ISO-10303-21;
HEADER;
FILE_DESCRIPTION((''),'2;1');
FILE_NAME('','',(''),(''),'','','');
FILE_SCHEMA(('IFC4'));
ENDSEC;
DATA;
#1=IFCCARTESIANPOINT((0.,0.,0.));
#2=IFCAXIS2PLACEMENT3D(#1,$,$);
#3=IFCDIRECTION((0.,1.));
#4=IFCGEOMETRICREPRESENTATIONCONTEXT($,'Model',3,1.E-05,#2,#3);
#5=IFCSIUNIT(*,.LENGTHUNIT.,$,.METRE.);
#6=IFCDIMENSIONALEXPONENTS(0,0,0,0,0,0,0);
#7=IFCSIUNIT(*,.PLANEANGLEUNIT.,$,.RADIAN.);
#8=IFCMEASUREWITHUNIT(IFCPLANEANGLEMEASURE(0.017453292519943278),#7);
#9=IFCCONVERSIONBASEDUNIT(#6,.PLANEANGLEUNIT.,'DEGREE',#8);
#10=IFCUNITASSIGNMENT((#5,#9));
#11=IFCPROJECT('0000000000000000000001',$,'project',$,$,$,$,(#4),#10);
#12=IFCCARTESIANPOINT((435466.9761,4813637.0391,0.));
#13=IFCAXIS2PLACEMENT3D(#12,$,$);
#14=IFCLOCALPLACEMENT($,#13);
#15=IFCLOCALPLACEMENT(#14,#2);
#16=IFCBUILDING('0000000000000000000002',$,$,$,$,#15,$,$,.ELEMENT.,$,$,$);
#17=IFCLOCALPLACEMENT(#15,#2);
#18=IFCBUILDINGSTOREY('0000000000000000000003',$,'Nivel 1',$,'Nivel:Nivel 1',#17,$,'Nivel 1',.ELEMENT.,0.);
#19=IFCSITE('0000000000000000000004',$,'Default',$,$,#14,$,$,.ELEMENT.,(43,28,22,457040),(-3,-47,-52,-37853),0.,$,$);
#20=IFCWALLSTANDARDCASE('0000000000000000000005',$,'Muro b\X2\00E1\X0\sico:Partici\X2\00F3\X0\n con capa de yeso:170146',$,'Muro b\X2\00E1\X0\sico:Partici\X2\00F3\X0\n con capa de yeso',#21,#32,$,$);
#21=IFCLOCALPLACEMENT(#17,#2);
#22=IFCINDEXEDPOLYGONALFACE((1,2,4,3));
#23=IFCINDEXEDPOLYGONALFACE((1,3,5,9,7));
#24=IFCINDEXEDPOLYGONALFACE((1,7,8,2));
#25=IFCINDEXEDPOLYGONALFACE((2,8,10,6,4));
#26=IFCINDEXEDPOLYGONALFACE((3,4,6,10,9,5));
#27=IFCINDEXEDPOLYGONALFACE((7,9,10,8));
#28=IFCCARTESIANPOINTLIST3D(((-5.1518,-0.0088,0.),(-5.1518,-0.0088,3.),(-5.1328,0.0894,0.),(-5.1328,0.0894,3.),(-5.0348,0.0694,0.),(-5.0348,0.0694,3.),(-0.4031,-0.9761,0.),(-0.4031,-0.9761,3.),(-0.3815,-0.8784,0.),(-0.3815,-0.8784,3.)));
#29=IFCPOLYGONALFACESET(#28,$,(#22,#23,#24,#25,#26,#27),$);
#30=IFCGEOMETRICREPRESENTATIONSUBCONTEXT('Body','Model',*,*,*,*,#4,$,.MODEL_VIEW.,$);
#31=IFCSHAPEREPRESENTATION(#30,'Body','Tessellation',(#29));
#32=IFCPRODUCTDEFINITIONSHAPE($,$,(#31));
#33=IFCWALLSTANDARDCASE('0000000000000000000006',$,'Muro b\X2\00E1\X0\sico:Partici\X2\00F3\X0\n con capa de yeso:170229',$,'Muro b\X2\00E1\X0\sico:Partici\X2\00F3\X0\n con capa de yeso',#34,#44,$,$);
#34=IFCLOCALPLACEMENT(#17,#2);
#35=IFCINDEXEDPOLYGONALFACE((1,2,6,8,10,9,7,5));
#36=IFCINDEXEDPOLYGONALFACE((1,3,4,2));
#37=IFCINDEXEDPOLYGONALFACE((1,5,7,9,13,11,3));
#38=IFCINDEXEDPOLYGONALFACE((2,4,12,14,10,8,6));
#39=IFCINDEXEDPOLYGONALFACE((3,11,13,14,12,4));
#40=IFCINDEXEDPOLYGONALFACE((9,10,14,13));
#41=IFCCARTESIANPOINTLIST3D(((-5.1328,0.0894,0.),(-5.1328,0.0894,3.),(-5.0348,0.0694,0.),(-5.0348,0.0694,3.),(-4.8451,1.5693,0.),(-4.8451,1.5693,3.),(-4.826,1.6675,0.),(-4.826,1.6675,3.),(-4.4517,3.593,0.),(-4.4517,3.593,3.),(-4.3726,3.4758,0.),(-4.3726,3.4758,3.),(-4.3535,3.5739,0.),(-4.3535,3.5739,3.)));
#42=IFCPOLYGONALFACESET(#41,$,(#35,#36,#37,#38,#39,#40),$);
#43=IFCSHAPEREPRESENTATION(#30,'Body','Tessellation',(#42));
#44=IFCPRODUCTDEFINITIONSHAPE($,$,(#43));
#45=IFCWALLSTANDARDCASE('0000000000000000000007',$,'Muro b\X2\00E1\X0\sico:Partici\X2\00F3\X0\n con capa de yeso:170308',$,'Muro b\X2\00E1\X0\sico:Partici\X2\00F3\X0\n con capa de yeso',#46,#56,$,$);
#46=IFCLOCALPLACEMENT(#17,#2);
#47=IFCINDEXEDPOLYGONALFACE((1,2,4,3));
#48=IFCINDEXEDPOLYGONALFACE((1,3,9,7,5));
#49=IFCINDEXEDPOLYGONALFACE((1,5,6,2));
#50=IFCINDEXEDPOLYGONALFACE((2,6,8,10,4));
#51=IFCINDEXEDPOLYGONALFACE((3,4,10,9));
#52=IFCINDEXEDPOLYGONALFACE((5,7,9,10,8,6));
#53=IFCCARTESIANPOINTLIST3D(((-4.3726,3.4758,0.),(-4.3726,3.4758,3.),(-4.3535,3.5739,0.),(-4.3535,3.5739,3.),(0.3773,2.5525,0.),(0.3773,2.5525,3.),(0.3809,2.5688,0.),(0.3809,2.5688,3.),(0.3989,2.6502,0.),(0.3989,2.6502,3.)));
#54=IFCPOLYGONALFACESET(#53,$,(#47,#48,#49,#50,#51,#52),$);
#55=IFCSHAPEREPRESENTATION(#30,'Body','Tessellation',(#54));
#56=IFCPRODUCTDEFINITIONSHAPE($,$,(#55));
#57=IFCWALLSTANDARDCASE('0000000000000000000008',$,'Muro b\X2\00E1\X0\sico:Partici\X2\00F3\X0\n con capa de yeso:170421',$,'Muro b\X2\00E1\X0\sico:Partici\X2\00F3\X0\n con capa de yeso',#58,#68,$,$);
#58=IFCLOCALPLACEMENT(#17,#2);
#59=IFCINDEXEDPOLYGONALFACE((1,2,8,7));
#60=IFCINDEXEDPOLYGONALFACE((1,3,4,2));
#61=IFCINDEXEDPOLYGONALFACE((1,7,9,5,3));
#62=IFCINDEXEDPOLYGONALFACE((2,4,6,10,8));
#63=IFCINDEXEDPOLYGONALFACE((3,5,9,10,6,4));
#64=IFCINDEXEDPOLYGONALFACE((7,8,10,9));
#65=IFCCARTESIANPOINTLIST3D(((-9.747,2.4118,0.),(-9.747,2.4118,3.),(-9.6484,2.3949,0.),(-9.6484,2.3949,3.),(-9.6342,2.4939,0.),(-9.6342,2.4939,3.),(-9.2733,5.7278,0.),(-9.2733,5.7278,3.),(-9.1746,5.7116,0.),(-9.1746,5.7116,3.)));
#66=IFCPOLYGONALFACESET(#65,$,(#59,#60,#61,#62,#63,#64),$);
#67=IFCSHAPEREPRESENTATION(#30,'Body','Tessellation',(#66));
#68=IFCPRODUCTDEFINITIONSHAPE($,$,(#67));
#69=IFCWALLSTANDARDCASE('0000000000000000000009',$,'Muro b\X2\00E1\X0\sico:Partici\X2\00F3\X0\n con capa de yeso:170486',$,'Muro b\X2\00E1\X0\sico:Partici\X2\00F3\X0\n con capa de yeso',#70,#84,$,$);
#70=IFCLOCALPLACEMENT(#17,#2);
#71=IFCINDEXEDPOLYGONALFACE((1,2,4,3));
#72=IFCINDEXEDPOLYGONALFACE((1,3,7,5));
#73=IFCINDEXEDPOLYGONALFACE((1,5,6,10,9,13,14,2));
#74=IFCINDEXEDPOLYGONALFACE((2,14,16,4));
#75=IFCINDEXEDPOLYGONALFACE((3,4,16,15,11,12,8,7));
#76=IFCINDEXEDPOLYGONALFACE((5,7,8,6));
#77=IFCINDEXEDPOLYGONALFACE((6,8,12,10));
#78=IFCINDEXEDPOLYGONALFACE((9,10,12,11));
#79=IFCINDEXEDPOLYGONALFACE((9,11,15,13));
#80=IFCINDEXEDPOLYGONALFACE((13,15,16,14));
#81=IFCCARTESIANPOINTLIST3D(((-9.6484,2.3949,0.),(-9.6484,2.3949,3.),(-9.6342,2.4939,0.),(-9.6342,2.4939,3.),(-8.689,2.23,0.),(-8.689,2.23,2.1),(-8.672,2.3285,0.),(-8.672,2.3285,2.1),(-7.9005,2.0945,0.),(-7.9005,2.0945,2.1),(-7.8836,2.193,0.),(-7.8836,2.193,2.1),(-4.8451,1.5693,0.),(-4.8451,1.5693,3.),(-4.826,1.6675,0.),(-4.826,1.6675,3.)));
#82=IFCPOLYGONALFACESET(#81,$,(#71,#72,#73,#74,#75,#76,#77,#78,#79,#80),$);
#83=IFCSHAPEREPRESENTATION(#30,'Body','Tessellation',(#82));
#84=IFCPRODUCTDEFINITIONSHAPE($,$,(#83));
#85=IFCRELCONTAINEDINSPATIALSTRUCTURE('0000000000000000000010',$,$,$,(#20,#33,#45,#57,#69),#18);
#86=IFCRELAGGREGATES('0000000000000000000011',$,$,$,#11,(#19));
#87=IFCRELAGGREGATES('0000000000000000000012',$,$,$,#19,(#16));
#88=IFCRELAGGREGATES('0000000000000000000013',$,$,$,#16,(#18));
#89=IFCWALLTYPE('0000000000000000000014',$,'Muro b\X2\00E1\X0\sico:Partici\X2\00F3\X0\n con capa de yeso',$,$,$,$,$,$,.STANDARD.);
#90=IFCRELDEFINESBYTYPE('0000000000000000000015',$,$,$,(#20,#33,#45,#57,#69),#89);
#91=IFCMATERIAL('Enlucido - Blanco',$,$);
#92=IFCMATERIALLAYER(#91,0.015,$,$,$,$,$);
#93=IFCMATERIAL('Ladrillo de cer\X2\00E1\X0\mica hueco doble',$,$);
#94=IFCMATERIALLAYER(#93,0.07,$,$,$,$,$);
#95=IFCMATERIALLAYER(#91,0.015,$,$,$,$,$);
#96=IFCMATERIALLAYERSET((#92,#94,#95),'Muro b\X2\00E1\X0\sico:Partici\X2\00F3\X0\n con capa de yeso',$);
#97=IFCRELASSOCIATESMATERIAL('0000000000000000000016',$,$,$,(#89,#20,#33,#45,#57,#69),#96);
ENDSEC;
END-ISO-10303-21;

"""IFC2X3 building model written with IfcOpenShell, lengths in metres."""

from ifc_helpers import new_model, entity, si_unit, converted_unit, direction, frame, frame_2d, origin, place, context, subcontext, project, spatial, polyline, rectangle, outline, extrude, material, layer, layer_set, layer_usage, type_object, element, save


model = new_model("IFC2X3")

# Units and contexts
model_context = context("Model", 3, precision=1e-05, world=origin(), true_north=direction((0.0, 1.0)))
body_context = subcontext(model_context, "Body", "Model", "MODEL_VIEW")
ifc_project = project(units=[si_unit("LENGTHUNIT", "METRE"), converted_unit("PLANEANGLEUNIT", "DEGREE", entity("IfcPlaneAngleMeasure", 0.017453292519943278), si_unit("PLANEANGLEUNIT", "RADIAN"), dimensions=[0, 0, 0, 0, 0, 0, 0])], contexts=[model_context])

# Site, building, storey
site_placement = place(None, frame((435466.9761, 4813637.0391, 0.0)))
site = spatial("IfcSite", under=ifc_project, at=site_placement, Name="Default", CompositionType="ELEMENT", RefLatitude=(43, 28, 22, 457040), RefLongitude=(-3, -47, -52, -37853), RefElevation=0.0)
building_placement = place(site_placement, origin())
building = spatial("IfcBuilding", under=site, at=building_placement, CompositionType="ELEMENT")
storey_placement = place(building_placement, origin())
storey = spatial("IfcBuildingStorey", under=building, at=storey_placement, Name="Nivel 1", ObjectType="Nivel:Nivel 1", LongName="Nivel 1", CompositionType="ELEMENT", Elevation=0.0)

# Shared definitions
ifc_material_1 = material(Name="Enlucido - Blanco")
ifc_layer_1 = layer(ifc_material_1, 0.015)
ifc_material_2 = material(Name="Ladrillo de cerámica hueco doble")
ifc_layer_2 = layer(ifc_material_2, 0.07)
ifc_layer_3 = layer(ifc_material_1, 0.015)
ifc_layer_set_1 = layer_set([ifc_layer_1, ifc_layer_2, ifc_layer_3], Name="Muro básico:Partición con capa de yeso")
wall_type_1 = type_object("IfcWallType", Name="Muro básico:Partición con capa de yeso", PredefinedType="STANDARD", material=ifc_layer_set_1)

# Walls
ifc_layer_usage_1 = layer_usage(ifc_layer_set_1, "AXIS2", "POSITIVE", -0.05)
wall_1_placement = place(storey_placement, frame((-0.3915, -0.9274, 0.0), z_axis=(0.0, 0.0, 1.0), x_axis=(-0.979879, 0.199592, 0.0)))
element("IfcWallStandardCase", 1, at=wall_1_placement, inside=storey, type_object=wall_type_1, material=ifc_layer_usage_1, Name="Muro básico:Partición con capa de yeso:170146", ObjectType="Muro básico:Partición con capa de yeso", context=body_context, shape_type="SweptSolid", body=[
    extrude(outline(polyline([(4.8488, -0.05), (4.8479, 0.05), (0.0017, 0.05), (0.0, -0.05), (4.7488, -0.05), (4.8488, -0.05)])), origin(), (0.0, 0.0, 1.0), 3.0),
])
ifc_layer_usage_2 = layer_usage(ifc_layer_set_1, "AXIS2", "POSITIVE", -0.05)
wall_2_placement = place(storey_placement, frame((-5.0838, 0.0789, 0.0), z_axis=(0.0, 0.0, 1.0), x_axis=(0.190809, 0.981627, 0.0)))
element("IfcWallStandardCase", 2, at=wall_2_placement, inside=storey, type_object=wall_type_1, material=ifc_layer_usage_2, Name="Muro básico:Partición con capa de yeso:170229", ObjectType="Muro básico:Partición con capa de yeso", context=body_context, shape_type="SweptSolid", body=[
    extrude(outline(polyline([(3.5701, -0.05), (3.5701, 0.05), (1.6086, 0.05), (1.5086, 0.05), (0.0009, 0.05), (0.0, -0.05), (3.4701, -0.05), (3.5701, -0.05)])), origin(), (0.0, 0.0, 1.0), 3.0),
])
ifc_layer_usage_3 = layer_usage(ifc_layer_set_1, "AXIS2", "POSITIVE", -0.05)
wall_3_placement = place(storey_placement, frame((-4.3631, 3.5249, 0.0), z_axis=(0.0, 0.0, 1.0), x_axis=(0.981627, -0.190809, 0.0)))
element("IfcWallStandardCase", 3, at=wall_3_placement, inside=storey, type_object=wall_type_1, material=ifc_layer_usage_3, Name="Muro básico:Partición con capa de yeso:170308", ObjectType="Muro básico:Partición con capa de yeso", context=body_context, shape_type="SweptSolid", body=[
    extrude(outline(polyline([(4.8388, -0.05), (4.8392, -0.0333), (4.8414, 0.05), (0.0, 0.05), (0.0, -0.05), (4.8388, -0.05)])), origin(), (0.0, 0.0, 1.0), 3.0),
])
ifc_layer_usage_4 = layer_usage(ifc_layer_set_1, "AXIS2", "NEGATIVE", 0.05)
wall_4_placement = place(storey_placement, frame((-9.2238, 5.7207, 0.0), z_axis=(0.0, 0.0, 1.0), x_axis=(-0.141418, -0.98995, 0.0)))
element("IfcWallStandardCase", 4, at=wall_4_placement, inside=storey, type_object=wall_type_1, material=ifc_layer_usage_4, Name="Muro básico:Partición con capa de yeso:170421", ObjectType="Muro básico:Partición con capa de yeso", context=body_context, shape_type="SweptSolid", body=[
    extrude(outline(polyline([(3.3496, -0.05), (3.3524, 0.05), (3.2524, 0.05), (0.002, 0.05), (0.0, -0.05), (3.3496, -0.05)])), origin(), (0.0, 0.0, 1.0), 3.0),
])

# Wall, opening
ifc_layer_usage_5 = layer_usage(ifc_layer_set_1, "AXIS2", "NEGATIVE", 0.05)
wall_5_placement = place(storey_placement, frame((-9.6427, 2.4446, 0.0), z_axis=(0.0, 0.0, 1.0), x_axis=(0.98555, -0.169385, 0.0)))
wall_5 = element("IfcWallStandardCase", 5, at=wall_5_placement, inside=storey, type_object=wall_type_1, material=ifc_layer_usage_5, Name="Muro básico:Partición con capa de yeso:170486", ObjectType="Muro básico:Partición con capa de yeso", context=body_context, shape_type="SweptSolid", body=[
    extrude(outline(polyline([(0.0028, -0.05), (4.8766, -0.05), (4.8787, 0.05), (0.0, 0.05), (0.0028, -0.05)])), origin(), (0.0, 0.0, 1.0), 3.0),
])
opening_1_placement = place(wall_5_placement, frame((1.7763, 0.05, 0.0)))
element("IfcOpeningElement", 6, at=opening_1_placement, cuts=wall_5, ObjectType="Opening", context=body_context, shape_type="SweptSolid", body=[
    extrude(rectangle(XDim=2.1, YDim=0.8, at=frame_2d((1.05, 0.4), x_axis=(1.0, 0.0))), frame((0.0, 0.0, 0.0), z_axis=(0.0, -1.0, 0.0), x_axis=(0.0, 0.0, 1.0)), (0.0, 0.0, 1.0), 0.1),
])

save(model, "model.ifc")
